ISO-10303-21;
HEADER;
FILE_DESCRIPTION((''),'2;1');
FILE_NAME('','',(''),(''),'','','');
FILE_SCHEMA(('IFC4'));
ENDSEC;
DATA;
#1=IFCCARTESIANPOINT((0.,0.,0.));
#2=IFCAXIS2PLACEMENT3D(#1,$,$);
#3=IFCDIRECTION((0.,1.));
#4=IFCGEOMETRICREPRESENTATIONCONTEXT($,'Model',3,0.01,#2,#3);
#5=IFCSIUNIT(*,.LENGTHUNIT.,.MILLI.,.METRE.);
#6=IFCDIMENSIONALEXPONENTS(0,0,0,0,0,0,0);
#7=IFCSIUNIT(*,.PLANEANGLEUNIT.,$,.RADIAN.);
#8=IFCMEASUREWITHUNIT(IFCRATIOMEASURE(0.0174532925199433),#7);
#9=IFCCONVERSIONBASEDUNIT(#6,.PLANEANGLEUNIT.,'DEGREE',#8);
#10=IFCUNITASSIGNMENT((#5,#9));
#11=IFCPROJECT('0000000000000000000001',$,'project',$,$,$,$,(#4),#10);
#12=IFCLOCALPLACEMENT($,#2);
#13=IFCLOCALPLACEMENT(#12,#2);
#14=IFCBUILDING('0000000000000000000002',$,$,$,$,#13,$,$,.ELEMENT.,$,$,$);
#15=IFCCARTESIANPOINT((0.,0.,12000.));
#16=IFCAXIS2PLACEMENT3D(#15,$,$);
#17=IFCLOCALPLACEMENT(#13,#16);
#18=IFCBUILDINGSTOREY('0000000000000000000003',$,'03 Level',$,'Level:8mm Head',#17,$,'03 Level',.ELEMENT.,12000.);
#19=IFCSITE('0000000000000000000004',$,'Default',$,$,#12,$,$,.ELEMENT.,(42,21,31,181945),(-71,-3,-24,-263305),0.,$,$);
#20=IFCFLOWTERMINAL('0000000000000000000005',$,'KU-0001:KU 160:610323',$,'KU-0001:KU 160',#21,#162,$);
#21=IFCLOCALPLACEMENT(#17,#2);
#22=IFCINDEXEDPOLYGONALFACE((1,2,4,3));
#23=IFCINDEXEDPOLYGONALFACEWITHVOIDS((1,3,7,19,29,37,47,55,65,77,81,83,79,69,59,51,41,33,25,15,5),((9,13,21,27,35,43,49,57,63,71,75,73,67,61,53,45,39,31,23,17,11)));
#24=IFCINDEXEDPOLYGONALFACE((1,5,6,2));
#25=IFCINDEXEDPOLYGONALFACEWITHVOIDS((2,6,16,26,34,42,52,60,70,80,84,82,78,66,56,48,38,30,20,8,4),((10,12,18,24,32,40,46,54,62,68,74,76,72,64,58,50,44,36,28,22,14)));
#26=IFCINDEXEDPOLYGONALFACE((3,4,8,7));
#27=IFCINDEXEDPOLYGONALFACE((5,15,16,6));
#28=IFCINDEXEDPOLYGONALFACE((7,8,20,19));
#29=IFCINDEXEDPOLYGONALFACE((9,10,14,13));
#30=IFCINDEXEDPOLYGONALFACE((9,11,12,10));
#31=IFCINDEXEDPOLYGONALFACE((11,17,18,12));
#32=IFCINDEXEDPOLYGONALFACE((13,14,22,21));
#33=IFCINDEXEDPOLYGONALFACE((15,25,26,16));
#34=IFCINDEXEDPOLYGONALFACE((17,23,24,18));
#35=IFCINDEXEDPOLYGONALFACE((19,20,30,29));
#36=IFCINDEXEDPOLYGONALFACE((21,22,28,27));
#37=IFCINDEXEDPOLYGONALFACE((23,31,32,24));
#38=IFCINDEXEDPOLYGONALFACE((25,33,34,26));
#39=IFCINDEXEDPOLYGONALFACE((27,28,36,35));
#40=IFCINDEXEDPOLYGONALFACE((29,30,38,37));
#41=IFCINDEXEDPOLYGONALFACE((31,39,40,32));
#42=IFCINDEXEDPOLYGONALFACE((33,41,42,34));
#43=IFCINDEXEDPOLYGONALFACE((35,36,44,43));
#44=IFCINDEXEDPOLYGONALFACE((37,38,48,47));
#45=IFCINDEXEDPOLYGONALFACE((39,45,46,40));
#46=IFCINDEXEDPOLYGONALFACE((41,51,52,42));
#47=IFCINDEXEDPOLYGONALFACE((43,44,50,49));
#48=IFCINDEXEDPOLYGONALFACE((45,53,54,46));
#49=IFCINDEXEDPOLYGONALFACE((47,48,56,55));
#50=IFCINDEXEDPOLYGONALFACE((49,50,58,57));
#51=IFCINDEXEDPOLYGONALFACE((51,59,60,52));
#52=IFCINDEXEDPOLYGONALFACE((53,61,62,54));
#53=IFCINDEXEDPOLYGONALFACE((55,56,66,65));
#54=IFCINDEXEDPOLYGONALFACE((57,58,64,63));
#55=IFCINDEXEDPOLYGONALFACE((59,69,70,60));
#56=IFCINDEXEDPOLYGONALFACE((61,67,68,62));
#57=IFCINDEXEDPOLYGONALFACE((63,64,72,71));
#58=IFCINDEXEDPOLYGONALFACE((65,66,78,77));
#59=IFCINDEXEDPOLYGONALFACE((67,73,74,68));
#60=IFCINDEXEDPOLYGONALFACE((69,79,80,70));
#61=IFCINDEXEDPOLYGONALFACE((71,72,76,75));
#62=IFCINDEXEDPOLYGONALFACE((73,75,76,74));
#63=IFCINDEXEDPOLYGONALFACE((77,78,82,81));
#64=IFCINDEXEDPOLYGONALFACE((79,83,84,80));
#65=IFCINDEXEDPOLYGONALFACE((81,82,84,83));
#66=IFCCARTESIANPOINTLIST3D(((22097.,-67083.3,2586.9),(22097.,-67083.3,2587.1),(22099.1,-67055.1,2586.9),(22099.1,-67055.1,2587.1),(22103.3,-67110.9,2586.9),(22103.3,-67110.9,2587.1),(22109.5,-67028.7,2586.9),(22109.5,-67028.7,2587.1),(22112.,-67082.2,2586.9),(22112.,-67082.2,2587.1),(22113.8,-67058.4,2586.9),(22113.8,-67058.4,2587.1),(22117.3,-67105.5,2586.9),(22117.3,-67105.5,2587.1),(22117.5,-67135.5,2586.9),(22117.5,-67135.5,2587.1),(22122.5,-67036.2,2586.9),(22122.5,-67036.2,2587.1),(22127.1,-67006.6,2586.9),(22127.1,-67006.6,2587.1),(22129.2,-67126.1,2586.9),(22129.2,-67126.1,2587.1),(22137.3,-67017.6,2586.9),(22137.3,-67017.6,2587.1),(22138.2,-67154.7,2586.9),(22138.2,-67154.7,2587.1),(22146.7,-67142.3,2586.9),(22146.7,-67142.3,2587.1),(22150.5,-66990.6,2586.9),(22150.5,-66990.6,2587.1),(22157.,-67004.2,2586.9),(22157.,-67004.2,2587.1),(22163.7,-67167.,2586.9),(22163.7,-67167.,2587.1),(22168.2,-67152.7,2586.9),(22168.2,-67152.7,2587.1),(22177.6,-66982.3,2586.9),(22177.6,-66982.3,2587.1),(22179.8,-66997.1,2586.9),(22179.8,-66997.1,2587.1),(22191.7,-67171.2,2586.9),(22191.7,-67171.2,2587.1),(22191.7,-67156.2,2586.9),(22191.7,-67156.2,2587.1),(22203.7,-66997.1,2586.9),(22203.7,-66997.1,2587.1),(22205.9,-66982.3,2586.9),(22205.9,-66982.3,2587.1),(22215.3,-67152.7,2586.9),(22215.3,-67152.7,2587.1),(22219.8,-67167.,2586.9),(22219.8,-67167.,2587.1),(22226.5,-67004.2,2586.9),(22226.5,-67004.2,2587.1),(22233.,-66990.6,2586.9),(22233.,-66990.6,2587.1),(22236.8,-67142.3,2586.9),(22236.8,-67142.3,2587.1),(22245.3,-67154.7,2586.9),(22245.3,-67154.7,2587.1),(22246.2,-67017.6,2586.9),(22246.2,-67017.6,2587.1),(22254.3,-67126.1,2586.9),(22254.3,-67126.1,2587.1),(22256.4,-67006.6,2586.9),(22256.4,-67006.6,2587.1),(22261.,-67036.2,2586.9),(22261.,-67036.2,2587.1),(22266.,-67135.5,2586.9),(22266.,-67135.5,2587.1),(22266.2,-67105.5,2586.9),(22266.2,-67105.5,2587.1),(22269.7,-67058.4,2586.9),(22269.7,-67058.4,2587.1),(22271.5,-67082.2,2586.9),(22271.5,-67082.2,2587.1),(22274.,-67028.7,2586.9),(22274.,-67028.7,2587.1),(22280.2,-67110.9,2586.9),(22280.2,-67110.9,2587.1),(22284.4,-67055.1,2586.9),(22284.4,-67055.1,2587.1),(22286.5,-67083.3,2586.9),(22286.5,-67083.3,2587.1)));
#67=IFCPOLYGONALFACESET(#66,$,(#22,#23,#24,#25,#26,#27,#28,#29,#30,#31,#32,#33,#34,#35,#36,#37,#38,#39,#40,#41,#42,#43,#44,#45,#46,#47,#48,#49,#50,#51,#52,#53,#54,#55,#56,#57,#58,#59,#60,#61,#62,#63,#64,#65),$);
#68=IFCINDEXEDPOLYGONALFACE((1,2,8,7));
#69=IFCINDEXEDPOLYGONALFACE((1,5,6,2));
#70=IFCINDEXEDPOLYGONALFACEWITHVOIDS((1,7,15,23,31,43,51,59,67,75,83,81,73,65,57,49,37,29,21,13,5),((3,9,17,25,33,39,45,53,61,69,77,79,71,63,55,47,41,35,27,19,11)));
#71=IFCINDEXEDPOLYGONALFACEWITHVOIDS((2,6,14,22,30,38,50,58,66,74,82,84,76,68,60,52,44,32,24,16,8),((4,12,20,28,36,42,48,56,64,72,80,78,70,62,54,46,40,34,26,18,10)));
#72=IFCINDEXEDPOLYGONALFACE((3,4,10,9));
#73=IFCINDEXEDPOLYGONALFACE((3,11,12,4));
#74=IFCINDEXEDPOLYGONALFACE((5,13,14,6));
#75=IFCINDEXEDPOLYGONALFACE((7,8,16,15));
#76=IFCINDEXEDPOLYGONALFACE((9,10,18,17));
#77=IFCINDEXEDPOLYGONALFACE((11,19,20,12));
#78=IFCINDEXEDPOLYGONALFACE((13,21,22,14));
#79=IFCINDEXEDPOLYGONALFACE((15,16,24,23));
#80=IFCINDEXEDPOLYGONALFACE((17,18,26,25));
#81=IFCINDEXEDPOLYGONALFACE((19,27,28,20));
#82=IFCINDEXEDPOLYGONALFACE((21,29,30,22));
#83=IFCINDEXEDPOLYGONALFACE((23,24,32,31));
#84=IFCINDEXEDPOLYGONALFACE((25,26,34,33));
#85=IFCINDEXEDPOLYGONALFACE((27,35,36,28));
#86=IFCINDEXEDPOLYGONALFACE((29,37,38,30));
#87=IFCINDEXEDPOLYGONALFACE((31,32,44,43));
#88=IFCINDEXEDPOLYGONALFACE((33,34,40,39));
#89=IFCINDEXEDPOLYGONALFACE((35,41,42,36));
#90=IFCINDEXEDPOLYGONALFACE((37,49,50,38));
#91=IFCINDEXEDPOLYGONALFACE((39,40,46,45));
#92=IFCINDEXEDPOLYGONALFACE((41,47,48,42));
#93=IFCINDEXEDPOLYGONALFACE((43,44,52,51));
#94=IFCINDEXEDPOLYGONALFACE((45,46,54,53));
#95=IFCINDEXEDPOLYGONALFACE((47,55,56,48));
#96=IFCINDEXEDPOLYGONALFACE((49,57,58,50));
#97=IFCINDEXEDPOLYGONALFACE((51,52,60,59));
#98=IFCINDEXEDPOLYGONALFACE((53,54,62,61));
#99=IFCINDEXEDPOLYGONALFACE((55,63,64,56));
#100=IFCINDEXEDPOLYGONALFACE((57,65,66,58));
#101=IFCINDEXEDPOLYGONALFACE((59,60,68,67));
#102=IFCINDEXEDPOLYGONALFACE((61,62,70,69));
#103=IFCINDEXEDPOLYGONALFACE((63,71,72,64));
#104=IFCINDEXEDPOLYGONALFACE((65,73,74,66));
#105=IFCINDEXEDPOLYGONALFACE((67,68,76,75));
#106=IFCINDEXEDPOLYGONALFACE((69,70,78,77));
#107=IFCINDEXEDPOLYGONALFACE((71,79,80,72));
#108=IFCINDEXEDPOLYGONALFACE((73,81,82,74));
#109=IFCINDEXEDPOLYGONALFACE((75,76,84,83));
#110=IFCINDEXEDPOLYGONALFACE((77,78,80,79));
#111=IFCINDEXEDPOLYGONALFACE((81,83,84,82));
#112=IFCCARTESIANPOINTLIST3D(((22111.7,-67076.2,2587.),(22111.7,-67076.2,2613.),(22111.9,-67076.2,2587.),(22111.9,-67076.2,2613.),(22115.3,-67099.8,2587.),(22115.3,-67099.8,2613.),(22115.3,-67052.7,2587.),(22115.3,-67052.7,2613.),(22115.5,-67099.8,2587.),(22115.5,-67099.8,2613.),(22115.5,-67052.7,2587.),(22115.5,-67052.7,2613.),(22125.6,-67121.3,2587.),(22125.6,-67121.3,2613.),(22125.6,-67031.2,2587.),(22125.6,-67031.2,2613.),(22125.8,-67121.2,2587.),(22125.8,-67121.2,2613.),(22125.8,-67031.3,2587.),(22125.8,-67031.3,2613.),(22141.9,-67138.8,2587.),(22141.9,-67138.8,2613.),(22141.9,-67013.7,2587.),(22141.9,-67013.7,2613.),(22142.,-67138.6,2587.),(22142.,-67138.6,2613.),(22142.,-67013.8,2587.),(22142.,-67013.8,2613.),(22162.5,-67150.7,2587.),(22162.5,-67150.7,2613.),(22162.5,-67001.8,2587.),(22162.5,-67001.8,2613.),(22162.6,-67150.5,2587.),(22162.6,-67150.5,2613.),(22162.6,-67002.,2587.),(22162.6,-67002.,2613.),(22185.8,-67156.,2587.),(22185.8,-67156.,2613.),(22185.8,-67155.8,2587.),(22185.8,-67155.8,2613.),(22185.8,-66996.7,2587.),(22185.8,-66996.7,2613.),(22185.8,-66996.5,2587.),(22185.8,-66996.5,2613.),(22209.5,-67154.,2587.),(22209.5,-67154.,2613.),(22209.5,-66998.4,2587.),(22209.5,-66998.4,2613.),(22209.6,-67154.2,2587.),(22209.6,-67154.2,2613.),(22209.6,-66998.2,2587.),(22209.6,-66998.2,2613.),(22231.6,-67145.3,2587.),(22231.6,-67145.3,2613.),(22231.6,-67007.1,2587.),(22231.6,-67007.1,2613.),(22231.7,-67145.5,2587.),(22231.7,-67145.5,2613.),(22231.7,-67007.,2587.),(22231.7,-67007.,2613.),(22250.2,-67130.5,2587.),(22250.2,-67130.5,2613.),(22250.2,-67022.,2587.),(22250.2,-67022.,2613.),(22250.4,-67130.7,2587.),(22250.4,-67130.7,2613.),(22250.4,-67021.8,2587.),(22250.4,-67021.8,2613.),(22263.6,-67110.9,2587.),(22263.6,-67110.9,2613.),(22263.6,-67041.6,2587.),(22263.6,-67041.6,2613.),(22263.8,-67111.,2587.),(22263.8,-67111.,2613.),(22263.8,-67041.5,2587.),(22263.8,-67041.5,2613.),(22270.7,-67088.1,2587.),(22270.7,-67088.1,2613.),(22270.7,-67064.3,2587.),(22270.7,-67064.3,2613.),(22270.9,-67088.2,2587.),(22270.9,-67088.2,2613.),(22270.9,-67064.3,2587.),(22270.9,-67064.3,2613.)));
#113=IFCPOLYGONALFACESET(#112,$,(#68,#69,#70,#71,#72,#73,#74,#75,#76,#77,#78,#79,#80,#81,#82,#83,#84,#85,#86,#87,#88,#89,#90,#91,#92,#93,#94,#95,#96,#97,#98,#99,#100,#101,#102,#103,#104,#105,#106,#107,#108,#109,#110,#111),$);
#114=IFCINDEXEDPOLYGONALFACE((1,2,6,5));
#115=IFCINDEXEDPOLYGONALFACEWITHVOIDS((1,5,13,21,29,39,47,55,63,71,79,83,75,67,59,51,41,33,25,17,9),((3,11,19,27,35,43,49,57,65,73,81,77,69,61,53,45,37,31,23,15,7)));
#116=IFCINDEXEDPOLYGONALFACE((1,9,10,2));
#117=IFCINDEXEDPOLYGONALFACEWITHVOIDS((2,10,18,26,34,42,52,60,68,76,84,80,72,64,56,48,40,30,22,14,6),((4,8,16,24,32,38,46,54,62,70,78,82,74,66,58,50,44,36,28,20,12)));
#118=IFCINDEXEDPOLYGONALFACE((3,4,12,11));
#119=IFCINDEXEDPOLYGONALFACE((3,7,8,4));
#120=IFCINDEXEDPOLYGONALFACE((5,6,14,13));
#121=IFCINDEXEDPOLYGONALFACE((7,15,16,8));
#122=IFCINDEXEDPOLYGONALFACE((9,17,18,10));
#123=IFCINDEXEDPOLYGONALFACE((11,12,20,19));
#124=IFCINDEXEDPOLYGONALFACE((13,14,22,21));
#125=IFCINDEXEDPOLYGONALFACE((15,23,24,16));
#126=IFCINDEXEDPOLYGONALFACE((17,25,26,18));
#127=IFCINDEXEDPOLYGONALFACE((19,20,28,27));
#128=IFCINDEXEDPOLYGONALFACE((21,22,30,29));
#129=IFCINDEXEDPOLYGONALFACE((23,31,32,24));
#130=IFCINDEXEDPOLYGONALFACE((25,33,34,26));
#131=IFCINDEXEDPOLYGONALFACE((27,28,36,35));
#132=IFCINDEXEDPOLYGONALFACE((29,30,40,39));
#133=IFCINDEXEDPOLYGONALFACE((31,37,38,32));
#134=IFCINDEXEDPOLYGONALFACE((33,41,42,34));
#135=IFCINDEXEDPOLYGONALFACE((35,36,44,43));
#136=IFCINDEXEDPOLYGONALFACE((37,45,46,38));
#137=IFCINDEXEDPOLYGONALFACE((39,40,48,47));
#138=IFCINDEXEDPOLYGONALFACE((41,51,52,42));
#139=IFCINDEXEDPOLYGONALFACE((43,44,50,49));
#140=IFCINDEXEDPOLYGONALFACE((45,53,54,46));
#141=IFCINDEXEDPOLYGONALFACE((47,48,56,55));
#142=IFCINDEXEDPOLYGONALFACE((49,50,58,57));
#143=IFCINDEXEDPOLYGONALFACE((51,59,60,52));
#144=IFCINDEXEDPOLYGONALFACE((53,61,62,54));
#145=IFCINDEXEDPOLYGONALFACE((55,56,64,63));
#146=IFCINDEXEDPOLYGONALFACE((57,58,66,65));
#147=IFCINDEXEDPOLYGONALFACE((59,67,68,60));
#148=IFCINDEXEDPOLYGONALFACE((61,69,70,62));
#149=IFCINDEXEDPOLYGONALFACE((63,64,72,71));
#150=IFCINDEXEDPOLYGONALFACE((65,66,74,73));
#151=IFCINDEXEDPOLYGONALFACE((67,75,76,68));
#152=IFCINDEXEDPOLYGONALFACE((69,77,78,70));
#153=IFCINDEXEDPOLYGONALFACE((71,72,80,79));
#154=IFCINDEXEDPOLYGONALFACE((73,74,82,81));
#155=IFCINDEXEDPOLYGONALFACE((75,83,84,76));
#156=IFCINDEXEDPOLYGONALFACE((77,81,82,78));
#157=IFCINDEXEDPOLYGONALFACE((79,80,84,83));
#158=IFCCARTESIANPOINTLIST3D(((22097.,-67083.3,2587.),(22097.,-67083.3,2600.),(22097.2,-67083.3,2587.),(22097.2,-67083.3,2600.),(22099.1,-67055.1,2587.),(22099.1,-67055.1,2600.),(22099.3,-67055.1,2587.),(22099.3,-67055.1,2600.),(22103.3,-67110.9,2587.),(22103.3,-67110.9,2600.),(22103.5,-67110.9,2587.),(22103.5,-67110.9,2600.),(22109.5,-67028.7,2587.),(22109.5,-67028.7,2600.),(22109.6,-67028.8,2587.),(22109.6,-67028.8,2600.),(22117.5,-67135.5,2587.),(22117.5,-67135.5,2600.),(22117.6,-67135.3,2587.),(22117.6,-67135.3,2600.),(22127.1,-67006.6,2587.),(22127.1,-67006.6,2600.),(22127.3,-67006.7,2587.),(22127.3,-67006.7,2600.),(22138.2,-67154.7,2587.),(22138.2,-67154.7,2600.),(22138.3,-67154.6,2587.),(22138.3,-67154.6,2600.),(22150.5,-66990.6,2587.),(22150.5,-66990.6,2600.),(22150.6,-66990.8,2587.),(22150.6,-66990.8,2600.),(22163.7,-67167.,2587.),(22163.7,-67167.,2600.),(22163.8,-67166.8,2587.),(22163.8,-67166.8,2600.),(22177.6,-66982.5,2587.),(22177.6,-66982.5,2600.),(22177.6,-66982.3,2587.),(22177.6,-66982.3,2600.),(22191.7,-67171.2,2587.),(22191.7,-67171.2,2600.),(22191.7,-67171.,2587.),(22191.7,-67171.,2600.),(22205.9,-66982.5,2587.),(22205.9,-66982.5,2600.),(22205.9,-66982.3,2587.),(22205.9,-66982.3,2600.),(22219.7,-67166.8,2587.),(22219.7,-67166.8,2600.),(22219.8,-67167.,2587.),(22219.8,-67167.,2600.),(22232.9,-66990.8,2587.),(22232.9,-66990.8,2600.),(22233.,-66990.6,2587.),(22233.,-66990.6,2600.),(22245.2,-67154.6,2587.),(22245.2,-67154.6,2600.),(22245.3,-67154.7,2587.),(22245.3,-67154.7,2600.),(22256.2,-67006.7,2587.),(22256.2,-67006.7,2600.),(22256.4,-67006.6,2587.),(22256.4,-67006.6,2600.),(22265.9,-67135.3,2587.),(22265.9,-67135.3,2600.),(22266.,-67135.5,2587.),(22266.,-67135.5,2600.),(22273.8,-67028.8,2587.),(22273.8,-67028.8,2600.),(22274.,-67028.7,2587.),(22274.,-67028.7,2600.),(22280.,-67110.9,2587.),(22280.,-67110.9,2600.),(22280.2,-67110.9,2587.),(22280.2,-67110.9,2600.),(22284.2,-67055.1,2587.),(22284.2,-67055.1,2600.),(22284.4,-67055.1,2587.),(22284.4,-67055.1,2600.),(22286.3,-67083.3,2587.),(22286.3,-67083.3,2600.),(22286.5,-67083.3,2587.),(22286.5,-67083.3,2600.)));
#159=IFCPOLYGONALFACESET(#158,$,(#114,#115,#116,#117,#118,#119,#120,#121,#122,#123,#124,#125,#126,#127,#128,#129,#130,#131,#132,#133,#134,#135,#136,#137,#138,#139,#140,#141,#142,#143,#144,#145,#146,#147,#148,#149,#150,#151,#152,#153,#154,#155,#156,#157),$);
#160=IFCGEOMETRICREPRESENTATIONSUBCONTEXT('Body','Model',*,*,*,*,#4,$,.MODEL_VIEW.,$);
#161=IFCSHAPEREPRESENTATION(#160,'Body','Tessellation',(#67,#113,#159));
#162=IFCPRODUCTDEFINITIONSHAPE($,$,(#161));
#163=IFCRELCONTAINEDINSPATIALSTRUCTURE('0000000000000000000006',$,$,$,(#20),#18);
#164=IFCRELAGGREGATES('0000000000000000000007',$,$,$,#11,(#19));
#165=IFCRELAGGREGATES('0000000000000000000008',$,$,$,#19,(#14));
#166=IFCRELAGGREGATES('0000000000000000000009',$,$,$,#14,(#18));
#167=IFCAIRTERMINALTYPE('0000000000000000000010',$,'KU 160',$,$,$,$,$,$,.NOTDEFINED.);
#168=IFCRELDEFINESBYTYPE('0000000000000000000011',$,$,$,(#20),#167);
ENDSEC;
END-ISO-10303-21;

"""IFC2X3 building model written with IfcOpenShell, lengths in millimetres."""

from ifc_helpers import new_model, entity, si_unit, converted_unit, direction, frame, frame_2d, origin, place, context, subcontext, project, spatial, hollow_circle, extrude, source, transform, mapped, type_object, type_shapes, element, save


model = new_model("IFC2X3")

# Units and contexts
model_context = context("Model", 3, precision=0.01, world=origin(), true_north=direction((0.0, 1.0)))
body_context = subcontext(model_context, "Body", "Model", "MODEL_VIEW")
ifc_project = project(units=[si_unit("LENGTHUNIT", "METRE", prefix="MILLI"), converted_unit("PLANEANGLEUNIT", "DEGREE", entity("IfcRatioMeasure", 0.0174532925199433), si_unit("PLANEANGLEUNIT", "RADIAN"), dimensions=[0, 0, 0, 0, 0, 0, 0])], contexts=[model_context])

# Site, building, storey
site_placement = place(None, origin())
site = spatial("IfcSite", under=ifc_project, at=site_placement, Name="Default", CompositionType="ELEMENT", RefLatitude=(42, 21, 31, 181945), RefLongitude=(-71, -3, -24, -263305), RefElevation=0.0)
building_placement = place(site_placement, origin())
building = spatial("IfcBuilding", under=site, at=building_placement, CompositionType="ELEMENT")
storey_placement = place(building_placement, frame((0.0, 0.0, 12000.0)))
storey = spatial("IfcBuildingStorey", under=building, at=storey_placement, Name="03 Level", ObjectType="Level:8mm Head", LongName="03 Level", CompositionType="ELEMENT", Elevation=12000.0)

# Flow terminal
air_terminal_type_1 = type_object("IfcAirTerminalType", Name="KU 160", PredefinedType="NOTDEFINED")
shared_shape_1 = source(origin(), body_context, "Body", "SweptSolid", [
    extrude(hollow_circle(Radius=95.0, WallThickness=15.0, at=frame_2d((0.0, 0.0), x_axis=(1.0, 0.0))), frame((12.9, 0.0, 0.0), z_axis=(1.0, 0.0, 0.0), x_axis=(0.0, -1.0, 0.0)), (0.0, 0.0, 1.0), 0.2),
    extrude(hollow_circle(Radius=80.0, WallThickness=0.2, at=frame_2d((0.0, 0.0), x_axis=(1.0, 0.0))), frame((-13.0, 0.0, 0.0), z_axis=(1.0, 0.0, 0.0), x_axis=(0.0, 0.0, -1.0)), (0.0, 0.0, 1.0), 26.0),
    extrude(hollow_circle(Radius=95.0, WallThickness=0.2, at=frame_2d((0.0, 0.0), x_axis=(1.0, 0.0))), frame((0.0, 0.0, 0.0), z_axis=(1.0, 0.0, 0.0), x_axis=(0.0, -1.0, 0.0)), (0.0, 0.0, 1.0), 13.0),
])
type_shapes(air_terminal_type_1, [shared_shape_1])
for number, where, z_axis, x_axis, name in (
    (1, (22191.7, -67076.2, 2600.0), (1.0, 0.0, 0.0), (0.0, 0.0, -1.0), "KU-0001:KU 160:610323"),
):
    element("IfcFlowTerminal", number, at=place(storey_placement, frame(where, z_axis=z_axis, x_axis=x_axis)), inside=storey, type_object=air_terminal_type_1, Name=name, ObjectType="KU-0001:KU 160", context=body_context, shape_type="MappedRepresentation", body=[
        mapped(shared_shape_1, transform((0.0, 0.0, 0.0), scale=1.0)),
    ])

save(model, "model.ifc")
